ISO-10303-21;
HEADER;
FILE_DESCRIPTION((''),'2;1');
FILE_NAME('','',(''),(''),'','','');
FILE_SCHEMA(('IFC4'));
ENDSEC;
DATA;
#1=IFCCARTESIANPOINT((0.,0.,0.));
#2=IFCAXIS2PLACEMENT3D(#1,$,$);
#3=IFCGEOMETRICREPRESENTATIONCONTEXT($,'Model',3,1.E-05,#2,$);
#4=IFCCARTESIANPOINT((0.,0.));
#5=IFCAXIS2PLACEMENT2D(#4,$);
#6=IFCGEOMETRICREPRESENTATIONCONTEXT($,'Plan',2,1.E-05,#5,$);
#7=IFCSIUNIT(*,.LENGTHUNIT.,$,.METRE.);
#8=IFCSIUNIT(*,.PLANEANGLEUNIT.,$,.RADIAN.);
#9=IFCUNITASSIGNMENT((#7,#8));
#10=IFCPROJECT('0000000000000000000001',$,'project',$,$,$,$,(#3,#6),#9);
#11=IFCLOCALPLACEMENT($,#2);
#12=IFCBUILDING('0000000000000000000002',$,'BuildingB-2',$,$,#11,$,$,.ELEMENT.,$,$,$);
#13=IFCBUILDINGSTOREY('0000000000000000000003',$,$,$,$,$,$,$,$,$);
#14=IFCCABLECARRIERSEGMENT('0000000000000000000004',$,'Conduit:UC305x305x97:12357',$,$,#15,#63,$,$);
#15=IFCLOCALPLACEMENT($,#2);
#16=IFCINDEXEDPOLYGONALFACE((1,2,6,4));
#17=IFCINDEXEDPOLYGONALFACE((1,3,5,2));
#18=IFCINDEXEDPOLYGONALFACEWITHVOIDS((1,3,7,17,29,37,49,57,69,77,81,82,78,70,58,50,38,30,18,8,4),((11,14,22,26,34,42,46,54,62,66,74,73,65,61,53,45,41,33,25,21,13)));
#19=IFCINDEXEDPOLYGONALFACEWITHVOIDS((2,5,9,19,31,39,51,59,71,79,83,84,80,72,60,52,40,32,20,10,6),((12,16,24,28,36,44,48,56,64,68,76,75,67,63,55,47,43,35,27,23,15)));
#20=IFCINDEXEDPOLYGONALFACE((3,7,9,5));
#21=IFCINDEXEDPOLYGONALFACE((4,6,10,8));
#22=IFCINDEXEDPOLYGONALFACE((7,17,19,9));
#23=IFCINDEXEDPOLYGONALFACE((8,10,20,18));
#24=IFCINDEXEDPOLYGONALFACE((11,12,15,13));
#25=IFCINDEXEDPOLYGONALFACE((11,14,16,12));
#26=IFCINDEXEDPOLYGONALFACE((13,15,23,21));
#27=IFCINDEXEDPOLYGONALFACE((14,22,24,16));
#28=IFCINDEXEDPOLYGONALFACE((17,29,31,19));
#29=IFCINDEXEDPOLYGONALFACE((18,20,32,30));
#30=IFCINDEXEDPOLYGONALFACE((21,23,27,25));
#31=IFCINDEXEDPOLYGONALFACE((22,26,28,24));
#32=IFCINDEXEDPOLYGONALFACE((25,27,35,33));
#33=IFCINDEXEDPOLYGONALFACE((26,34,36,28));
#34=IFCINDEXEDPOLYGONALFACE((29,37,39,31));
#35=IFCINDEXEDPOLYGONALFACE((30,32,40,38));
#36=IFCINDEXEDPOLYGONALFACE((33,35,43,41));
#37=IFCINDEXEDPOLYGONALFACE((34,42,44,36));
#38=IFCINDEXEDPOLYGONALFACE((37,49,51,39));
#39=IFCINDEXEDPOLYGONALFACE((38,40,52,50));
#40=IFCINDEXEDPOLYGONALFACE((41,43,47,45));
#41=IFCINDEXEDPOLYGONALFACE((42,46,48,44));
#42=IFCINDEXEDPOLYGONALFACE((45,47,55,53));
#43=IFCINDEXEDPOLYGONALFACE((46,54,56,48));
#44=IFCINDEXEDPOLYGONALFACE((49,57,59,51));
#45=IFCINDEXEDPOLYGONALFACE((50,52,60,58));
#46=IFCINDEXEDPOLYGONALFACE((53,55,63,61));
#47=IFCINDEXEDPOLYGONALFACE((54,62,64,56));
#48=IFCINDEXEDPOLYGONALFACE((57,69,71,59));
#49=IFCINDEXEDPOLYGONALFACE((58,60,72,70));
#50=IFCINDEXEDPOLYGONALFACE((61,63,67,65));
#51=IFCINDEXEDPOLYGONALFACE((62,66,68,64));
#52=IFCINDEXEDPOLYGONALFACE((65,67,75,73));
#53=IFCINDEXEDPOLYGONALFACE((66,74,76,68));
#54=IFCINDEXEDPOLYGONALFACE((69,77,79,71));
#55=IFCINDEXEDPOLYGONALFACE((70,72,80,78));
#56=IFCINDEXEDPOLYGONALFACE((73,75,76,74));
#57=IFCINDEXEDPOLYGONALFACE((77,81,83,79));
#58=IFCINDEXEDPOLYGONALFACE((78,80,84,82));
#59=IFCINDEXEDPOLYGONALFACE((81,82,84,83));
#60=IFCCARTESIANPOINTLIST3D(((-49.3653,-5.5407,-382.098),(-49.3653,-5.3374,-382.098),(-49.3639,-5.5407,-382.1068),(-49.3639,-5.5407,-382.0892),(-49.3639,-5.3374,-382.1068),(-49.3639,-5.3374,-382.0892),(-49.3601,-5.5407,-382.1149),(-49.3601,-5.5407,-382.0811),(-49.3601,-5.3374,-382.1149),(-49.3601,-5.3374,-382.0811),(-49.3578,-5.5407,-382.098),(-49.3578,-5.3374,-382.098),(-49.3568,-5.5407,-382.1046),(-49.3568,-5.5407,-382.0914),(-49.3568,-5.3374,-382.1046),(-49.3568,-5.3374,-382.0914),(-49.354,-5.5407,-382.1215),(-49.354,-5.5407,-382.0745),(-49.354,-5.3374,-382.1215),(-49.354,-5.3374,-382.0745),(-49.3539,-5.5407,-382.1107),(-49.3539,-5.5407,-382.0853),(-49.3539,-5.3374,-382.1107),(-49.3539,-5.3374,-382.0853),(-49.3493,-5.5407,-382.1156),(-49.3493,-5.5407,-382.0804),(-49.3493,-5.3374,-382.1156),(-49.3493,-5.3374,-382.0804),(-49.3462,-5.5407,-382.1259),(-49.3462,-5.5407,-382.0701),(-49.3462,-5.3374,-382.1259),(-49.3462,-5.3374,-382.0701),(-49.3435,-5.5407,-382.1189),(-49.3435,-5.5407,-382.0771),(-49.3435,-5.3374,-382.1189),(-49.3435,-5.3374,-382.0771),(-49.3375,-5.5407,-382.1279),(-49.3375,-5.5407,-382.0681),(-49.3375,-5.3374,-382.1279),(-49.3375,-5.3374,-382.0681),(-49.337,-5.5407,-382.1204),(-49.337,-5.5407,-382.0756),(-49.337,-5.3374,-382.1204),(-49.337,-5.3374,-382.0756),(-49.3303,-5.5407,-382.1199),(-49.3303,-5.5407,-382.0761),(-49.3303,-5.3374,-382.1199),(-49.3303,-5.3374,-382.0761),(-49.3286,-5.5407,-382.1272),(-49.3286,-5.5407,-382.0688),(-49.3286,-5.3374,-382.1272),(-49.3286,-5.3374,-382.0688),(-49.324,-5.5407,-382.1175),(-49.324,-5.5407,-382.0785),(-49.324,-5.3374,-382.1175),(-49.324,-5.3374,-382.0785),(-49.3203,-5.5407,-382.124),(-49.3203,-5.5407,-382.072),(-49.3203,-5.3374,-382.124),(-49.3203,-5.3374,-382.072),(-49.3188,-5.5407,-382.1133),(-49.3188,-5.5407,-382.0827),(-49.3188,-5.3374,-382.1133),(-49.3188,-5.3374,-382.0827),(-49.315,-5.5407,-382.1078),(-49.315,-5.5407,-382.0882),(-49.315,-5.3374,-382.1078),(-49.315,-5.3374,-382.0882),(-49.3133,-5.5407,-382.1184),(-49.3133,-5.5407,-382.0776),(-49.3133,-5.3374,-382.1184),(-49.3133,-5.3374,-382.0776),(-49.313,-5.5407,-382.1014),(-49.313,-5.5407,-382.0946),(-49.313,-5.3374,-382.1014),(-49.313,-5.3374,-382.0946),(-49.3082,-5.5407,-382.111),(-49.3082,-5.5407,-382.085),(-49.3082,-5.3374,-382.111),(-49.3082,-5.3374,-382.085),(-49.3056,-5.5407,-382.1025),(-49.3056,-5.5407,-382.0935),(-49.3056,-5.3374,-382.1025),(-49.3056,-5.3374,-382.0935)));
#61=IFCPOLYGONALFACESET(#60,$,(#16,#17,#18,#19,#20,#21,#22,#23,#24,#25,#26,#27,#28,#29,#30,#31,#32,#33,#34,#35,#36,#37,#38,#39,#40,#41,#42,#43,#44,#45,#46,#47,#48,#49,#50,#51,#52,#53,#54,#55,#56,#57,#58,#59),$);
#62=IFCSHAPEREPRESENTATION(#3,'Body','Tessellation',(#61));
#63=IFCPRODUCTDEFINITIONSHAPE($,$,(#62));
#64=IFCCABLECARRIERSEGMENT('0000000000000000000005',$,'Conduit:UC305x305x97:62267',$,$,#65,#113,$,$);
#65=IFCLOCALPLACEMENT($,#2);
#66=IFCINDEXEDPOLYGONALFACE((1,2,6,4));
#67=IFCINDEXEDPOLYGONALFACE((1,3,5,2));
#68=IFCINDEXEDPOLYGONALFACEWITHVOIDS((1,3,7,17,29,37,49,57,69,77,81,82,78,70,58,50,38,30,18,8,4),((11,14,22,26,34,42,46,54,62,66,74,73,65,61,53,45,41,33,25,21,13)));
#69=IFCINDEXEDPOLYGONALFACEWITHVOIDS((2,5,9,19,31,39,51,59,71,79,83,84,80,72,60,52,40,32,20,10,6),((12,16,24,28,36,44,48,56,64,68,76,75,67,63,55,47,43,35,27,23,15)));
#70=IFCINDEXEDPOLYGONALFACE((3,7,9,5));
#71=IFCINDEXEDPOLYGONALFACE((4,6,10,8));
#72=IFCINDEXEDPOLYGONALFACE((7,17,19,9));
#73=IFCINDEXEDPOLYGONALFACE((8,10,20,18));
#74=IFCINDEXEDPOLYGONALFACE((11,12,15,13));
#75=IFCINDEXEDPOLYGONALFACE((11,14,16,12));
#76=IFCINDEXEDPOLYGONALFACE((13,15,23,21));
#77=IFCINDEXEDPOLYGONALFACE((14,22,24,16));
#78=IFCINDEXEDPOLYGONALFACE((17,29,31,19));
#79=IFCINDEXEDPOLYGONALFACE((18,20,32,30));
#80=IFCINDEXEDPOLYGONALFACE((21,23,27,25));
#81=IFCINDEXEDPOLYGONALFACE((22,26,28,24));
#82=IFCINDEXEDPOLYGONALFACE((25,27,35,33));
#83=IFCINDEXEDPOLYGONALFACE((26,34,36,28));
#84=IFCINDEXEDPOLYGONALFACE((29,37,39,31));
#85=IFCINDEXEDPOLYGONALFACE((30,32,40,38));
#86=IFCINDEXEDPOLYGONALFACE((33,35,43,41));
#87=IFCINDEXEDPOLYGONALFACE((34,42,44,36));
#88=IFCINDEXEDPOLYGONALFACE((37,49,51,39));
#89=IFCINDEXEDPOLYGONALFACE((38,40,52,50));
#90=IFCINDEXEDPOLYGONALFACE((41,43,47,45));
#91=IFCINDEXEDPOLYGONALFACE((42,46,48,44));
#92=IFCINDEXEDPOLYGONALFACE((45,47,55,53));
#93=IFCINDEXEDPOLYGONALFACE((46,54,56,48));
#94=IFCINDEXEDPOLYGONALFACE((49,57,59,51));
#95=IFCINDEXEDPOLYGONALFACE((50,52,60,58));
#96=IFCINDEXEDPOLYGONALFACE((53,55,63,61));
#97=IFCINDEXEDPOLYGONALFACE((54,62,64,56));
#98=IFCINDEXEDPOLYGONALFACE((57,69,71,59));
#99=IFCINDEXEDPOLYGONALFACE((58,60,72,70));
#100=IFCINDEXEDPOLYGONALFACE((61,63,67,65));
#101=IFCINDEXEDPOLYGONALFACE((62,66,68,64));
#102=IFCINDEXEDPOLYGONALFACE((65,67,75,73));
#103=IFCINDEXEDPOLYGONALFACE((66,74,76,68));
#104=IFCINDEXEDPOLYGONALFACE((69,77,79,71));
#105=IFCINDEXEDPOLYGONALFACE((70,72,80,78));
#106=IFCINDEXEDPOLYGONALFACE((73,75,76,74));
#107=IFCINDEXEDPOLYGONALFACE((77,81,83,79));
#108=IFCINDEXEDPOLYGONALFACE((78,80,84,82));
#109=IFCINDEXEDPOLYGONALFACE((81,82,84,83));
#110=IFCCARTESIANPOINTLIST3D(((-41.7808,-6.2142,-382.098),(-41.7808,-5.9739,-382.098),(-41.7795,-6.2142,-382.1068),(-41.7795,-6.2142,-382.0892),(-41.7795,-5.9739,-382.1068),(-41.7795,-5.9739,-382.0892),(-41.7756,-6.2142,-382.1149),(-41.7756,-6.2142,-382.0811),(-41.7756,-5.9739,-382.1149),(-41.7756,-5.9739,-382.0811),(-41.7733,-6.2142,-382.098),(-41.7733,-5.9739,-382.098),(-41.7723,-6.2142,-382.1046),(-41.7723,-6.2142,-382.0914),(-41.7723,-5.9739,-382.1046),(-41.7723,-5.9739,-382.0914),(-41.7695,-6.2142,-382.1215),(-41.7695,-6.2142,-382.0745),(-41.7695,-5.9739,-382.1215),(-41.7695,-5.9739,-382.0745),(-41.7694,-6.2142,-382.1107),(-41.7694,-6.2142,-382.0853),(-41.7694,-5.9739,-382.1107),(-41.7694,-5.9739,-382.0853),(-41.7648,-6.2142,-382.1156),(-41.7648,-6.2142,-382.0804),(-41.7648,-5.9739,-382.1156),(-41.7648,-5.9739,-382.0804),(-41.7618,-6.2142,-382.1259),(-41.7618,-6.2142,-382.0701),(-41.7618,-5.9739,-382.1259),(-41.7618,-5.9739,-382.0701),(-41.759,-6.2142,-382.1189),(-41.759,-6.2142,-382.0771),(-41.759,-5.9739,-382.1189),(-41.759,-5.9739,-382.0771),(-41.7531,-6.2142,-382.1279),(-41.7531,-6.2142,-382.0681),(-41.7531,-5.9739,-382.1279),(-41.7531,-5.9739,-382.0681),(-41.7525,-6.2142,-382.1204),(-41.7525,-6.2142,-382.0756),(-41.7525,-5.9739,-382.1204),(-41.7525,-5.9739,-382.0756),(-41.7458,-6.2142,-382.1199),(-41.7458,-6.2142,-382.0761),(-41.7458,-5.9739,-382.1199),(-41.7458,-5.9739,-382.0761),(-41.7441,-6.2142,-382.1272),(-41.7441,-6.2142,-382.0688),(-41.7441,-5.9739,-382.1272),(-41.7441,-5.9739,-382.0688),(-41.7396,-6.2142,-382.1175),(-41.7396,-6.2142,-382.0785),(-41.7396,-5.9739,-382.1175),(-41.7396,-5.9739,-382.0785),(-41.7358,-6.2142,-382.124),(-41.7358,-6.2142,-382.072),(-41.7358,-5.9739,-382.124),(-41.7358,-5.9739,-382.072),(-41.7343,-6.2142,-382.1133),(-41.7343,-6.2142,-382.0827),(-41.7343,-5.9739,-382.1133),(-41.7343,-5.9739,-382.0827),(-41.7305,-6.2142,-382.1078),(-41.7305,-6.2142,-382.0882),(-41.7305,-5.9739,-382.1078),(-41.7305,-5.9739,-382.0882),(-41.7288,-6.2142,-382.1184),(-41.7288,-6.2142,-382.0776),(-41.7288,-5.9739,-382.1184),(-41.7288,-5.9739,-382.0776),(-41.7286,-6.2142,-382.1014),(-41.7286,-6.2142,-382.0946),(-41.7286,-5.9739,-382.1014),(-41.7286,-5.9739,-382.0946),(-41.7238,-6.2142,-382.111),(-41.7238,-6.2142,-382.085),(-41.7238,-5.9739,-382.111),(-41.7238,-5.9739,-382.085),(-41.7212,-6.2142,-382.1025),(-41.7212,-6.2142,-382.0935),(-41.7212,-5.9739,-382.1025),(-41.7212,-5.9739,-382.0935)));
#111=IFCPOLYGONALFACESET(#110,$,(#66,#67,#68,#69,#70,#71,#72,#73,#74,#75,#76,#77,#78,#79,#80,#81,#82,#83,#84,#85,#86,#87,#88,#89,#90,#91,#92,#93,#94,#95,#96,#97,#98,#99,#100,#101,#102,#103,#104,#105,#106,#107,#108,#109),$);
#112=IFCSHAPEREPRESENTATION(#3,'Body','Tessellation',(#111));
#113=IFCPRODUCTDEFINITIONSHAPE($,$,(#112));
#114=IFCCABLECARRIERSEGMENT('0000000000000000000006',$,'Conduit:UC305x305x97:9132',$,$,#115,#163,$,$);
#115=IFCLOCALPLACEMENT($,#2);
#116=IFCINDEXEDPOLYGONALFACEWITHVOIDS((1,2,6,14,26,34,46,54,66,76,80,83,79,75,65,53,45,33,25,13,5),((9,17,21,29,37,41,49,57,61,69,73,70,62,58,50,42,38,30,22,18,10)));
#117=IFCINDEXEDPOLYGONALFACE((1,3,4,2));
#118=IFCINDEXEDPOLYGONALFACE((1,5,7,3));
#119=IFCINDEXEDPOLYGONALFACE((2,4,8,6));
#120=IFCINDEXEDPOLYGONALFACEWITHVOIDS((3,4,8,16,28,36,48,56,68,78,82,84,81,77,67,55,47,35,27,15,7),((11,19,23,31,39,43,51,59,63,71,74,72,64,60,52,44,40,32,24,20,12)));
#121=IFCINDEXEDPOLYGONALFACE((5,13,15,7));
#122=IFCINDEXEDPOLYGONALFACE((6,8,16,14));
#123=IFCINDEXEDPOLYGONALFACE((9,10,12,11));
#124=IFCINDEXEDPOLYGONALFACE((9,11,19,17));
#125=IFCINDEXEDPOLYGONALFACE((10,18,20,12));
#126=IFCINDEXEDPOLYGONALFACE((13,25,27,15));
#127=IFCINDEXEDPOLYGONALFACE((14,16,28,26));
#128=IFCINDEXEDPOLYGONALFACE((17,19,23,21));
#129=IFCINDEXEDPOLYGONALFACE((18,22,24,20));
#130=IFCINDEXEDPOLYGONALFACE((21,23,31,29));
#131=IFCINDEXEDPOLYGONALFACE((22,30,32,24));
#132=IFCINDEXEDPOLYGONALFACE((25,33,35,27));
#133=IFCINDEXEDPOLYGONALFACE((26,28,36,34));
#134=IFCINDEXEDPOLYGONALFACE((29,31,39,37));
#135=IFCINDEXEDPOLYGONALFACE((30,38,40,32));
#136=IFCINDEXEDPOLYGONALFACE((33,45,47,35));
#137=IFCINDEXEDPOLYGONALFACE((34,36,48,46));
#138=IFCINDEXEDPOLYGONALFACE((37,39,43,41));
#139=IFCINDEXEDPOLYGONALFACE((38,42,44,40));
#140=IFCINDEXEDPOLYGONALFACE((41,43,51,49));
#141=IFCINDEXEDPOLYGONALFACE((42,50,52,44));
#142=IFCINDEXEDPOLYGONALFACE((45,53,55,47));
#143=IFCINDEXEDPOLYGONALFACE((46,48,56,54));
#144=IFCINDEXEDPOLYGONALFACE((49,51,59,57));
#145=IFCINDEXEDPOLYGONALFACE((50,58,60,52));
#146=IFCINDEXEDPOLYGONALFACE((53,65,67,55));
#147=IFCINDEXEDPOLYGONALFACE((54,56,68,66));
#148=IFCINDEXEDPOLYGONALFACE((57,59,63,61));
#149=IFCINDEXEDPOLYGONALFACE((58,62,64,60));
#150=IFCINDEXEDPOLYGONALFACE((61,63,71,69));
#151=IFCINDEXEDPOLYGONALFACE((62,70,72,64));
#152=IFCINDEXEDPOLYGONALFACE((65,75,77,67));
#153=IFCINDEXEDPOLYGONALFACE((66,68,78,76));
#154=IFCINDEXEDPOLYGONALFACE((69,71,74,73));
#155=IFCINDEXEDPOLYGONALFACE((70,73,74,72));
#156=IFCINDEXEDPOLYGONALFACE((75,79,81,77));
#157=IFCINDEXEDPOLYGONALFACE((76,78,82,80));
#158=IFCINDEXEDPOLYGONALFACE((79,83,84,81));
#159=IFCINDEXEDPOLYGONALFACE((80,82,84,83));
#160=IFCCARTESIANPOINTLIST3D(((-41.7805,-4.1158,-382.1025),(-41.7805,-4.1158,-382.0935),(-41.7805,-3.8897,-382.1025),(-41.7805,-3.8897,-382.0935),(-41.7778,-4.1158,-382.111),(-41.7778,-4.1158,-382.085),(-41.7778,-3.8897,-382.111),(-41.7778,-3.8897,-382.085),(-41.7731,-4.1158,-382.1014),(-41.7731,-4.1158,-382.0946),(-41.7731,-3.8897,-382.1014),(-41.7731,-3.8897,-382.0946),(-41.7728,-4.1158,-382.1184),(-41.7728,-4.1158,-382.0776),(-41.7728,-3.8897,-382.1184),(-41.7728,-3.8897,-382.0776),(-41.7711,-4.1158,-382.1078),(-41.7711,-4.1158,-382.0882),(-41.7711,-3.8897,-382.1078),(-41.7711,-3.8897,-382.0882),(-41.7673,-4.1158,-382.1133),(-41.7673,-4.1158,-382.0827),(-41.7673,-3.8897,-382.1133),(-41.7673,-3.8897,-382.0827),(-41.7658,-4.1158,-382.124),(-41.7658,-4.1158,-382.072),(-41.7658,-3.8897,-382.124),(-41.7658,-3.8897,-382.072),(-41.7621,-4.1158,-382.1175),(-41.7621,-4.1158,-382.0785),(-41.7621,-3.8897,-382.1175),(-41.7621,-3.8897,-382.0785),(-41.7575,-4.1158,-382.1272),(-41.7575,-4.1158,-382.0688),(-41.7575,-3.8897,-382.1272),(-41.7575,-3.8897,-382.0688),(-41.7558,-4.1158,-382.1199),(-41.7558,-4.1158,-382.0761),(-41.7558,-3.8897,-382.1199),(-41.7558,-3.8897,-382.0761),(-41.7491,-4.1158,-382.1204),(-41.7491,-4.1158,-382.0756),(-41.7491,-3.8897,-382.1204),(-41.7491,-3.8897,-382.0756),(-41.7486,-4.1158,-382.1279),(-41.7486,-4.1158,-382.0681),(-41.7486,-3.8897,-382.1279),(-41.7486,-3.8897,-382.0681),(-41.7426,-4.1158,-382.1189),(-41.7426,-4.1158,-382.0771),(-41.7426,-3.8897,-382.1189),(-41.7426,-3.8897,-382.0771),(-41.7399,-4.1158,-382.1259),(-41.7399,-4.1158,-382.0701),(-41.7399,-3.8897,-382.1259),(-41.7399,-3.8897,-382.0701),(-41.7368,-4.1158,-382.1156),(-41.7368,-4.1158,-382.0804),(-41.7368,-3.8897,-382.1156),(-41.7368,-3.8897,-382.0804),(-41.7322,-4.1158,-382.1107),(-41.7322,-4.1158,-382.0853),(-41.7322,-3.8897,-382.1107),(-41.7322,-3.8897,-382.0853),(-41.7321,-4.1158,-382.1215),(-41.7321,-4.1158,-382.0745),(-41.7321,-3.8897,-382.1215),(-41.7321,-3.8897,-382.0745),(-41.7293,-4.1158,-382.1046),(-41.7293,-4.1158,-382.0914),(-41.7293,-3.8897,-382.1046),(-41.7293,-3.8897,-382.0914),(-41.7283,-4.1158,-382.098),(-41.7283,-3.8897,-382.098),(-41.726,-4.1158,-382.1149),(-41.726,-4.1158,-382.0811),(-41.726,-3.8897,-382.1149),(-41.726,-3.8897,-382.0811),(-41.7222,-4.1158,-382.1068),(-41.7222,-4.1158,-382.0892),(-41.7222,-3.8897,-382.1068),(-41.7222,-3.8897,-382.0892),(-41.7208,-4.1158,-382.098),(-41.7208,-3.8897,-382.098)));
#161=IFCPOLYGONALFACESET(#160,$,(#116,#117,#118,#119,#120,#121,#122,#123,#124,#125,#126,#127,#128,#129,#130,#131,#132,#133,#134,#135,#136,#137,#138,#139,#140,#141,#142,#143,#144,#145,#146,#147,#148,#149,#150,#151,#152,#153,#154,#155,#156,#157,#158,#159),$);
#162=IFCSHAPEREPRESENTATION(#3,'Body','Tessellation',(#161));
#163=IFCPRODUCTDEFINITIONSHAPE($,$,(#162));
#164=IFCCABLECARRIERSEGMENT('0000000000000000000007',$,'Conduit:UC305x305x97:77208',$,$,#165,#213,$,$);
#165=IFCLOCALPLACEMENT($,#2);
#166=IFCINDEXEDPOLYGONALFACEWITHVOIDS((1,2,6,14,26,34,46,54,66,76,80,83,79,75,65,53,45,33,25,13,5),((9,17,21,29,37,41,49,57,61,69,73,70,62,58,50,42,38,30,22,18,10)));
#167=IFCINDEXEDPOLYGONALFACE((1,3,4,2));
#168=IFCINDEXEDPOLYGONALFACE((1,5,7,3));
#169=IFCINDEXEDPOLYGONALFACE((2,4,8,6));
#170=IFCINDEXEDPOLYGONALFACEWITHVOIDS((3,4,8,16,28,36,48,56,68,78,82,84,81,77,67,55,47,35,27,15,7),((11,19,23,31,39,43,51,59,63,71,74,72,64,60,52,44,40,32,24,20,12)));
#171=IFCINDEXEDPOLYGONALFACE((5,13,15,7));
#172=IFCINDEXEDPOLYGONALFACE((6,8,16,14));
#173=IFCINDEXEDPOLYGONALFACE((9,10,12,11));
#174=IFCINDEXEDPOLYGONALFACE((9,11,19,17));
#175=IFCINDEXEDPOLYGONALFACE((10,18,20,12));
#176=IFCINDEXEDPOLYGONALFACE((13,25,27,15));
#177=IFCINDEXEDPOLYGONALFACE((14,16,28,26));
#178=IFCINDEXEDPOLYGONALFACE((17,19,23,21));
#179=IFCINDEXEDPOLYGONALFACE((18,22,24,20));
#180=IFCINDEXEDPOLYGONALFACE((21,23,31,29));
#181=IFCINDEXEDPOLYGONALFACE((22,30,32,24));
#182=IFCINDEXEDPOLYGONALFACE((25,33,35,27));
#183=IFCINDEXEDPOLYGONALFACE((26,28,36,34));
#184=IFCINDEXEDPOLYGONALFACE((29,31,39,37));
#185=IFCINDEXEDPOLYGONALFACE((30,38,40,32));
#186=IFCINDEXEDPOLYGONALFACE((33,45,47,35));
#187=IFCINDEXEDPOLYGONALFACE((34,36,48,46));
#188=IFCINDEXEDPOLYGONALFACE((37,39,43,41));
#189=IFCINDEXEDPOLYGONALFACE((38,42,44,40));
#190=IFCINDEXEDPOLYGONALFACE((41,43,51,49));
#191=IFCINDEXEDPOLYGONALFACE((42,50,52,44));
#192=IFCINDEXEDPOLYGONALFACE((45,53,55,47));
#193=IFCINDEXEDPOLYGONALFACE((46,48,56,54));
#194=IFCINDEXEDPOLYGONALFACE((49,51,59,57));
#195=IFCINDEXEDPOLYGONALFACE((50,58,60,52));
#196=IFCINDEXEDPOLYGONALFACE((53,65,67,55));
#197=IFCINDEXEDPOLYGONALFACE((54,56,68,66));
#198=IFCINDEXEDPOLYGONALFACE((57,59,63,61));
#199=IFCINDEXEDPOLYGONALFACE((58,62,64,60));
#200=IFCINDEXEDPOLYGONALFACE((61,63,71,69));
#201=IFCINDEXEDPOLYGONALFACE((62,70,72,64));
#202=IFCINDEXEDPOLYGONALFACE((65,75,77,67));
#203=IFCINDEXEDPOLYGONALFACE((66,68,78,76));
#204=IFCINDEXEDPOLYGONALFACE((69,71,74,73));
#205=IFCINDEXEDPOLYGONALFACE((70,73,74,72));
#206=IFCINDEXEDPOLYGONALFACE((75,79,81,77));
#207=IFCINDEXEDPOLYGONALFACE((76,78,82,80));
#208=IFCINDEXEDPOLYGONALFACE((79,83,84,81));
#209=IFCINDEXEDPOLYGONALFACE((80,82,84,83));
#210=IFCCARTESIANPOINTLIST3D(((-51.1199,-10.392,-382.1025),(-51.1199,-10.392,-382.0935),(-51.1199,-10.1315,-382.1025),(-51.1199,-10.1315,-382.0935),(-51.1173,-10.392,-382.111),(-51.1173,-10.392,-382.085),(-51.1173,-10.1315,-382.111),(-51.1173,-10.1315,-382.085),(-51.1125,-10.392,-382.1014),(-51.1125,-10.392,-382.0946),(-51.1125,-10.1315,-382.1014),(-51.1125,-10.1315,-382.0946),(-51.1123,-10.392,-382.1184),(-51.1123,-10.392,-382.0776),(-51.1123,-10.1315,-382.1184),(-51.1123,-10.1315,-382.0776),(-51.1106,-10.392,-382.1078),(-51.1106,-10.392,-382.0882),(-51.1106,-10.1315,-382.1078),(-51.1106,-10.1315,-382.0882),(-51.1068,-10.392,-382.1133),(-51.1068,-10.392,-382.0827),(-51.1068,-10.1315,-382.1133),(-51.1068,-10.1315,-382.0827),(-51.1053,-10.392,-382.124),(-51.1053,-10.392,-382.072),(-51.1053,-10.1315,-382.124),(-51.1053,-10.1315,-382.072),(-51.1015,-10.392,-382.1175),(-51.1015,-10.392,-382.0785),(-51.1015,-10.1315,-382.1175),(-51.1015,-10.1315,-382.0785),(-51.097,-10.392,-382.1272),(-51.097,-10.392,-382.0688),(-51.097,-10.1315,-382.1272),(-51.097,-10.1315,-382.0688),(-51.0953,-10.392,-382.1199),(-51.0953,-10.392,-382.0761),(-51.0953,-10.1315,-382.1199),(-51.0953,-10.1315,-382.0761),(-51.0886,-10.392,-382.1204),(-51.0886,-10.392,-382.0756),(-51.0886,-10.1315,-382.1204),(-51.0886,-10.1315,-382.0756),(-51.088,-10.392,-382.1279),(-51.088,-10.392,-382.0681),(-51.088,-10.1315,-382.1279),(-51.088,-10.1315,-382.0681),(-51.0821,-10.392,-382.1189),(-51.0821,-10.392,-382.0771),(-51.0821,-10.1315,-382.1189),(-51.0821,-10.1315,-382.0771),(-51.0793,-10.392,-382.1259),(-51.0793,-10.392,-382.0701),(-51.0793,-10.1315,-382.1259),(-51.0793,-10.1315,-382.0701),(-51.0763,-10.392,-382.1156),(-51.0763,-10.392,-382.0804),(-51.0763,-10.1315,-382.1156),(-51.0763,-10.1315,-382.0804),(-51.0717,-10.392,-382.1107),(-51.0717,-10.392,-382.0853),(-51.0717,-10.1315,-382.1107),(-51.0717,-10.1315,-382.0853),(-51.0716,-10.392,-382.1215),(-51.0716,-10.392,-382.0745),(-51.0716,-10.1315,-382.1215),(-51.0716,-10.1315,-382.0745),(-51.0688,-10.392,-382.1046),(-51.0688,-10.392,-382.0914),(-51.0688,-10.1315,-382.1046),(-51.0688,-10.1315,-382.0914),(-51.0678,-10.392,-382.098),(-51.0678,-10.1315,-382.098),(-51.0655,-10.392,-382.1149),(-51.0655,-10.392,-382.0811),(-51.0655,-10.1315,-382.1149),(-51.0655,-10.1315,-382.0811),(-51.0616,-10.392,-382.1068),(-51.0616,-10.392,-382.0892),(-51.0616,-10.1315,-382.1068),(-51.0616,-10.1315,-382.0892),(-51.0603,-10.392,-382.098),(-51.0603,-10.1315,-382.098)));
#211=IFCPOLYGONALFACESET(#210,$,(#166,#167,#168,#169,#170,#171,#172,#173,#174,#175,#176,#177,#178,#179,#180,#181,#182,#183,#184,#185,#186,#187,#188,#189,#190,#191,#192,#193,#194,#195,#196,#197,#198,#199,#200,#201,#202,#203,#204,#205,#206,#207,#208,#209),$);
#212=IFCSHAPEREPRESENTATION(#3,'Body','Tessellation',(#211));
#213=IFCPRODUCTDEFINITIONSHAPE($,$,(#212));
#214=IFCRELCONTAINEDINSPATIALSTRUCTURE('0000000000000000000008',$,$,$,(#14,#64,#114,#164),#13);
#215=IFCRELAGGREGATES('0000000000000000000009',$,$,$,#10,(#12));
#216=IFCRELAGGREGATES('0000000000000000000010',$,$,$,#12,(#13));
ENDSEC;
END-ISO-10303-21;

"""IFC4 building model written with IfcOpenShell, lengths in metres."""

from ifc_helpers import new_model, entity, si_unit, origin, origin_2d, place, context, project, spatial, element, save


model = new_model("IFC4")

# Units and contexts
model_context = context("Model", 3, precision=1e-05, world=origin())
plan_context = context("Plan", 2, precision=1e-05, world=origin_2d())
ifc_project = project(units=[si_unit("LENGTHUNIT", "METRE"), si_unit("PLANEANGLEUNIT", "RADIAN")], contexts=[model_context, plan_context])

# Building, storey
building_placement = place(None, origin())
building = spatial("IfcBuilding", under=ifc_project, at=building_placement, Name="BuildingB-2", CompositionType="ELEMENT")
storey = spatial("IfcBuildingStorey", under=building)

# Cable carrier segments
element("IfcCableCarrierSegment", 1, inside=storey, Name="Conduit:UC305x305x97:12357", context=model_context, shape_type="AdvancedSweptSolid", body=[
    entity("IfcSweptDiskSolid", entity("IfcCompositeCurve", [entity("IfcCompositeCurveSegment", "CONTINUOUS", False, entity("IfcPolyline", [entity("IfcCartesianPoint", [49.3353, 5.5407, 382.098]), entity("IfcCartesianPoint", [49.3353, 5.3374, 382.098])]))], False), 0.03, 0.0225),
])
element("IfcCableCarrierSegment", 2, inside=storey, Name="Conduit:UC305x305x97:62267", context=model_context, shape_type="AdvancedSweptSolid", body=[
    entity("IfcSweptDiskSolid", entity("IfcCompositeCurve", [entity("IfcCompositeCurveSegment", "CONTINUOUS", False, entity("IfcPolyline", [entity("IfcCartesianPoint", [41.7508, 6.2142, 382.098]), entity("IfcCartesianPoint", [41.7508, 5.9739, 382.098])]))], False), 0.03, 0.0225),
])
element("IfcCableCarrierSegment", 3, inside=storey, Name="Conduit:UC305x305x97:9132", context=model_context, shape_type="AdvancedSweptSolid", body=[
    entity("IfcSweptDiskSolid", entity("IfcCompositeCurve", [entity("IfcCompositeCurveSegment", "CONTINUOUS", False, entity("IfcPolyline", [entity("IfcCartesianPoint", [41.7508, 3.8897, 382.098]), entity("IfcCartesianPoint", [41.7508, 4.1158, 382.098])]))], False), 0.03, 0.0225),
])
element("IfcCableCarrierSegment", 4, inside=storey, Name="Conduit:UC305x305x97:77208", context=model_context, shape_type="AdvancedSweptSolid", body=[
    entity("IfcSweptDiskSolid", entity("IfcCompositeCurve", [entity("IfcCompositeCurveSegment", "CONTINUOUS", False, entity("IfcPolyline", [entity("IfcCartesianPoint", [51.0903, 10.1315, 382.098]), entity("IfcCartesianPoint", [51.0903, 10.392, 382.098])]))], False), 0.03, 0.0225),
])

save(model, "model.ifc")
